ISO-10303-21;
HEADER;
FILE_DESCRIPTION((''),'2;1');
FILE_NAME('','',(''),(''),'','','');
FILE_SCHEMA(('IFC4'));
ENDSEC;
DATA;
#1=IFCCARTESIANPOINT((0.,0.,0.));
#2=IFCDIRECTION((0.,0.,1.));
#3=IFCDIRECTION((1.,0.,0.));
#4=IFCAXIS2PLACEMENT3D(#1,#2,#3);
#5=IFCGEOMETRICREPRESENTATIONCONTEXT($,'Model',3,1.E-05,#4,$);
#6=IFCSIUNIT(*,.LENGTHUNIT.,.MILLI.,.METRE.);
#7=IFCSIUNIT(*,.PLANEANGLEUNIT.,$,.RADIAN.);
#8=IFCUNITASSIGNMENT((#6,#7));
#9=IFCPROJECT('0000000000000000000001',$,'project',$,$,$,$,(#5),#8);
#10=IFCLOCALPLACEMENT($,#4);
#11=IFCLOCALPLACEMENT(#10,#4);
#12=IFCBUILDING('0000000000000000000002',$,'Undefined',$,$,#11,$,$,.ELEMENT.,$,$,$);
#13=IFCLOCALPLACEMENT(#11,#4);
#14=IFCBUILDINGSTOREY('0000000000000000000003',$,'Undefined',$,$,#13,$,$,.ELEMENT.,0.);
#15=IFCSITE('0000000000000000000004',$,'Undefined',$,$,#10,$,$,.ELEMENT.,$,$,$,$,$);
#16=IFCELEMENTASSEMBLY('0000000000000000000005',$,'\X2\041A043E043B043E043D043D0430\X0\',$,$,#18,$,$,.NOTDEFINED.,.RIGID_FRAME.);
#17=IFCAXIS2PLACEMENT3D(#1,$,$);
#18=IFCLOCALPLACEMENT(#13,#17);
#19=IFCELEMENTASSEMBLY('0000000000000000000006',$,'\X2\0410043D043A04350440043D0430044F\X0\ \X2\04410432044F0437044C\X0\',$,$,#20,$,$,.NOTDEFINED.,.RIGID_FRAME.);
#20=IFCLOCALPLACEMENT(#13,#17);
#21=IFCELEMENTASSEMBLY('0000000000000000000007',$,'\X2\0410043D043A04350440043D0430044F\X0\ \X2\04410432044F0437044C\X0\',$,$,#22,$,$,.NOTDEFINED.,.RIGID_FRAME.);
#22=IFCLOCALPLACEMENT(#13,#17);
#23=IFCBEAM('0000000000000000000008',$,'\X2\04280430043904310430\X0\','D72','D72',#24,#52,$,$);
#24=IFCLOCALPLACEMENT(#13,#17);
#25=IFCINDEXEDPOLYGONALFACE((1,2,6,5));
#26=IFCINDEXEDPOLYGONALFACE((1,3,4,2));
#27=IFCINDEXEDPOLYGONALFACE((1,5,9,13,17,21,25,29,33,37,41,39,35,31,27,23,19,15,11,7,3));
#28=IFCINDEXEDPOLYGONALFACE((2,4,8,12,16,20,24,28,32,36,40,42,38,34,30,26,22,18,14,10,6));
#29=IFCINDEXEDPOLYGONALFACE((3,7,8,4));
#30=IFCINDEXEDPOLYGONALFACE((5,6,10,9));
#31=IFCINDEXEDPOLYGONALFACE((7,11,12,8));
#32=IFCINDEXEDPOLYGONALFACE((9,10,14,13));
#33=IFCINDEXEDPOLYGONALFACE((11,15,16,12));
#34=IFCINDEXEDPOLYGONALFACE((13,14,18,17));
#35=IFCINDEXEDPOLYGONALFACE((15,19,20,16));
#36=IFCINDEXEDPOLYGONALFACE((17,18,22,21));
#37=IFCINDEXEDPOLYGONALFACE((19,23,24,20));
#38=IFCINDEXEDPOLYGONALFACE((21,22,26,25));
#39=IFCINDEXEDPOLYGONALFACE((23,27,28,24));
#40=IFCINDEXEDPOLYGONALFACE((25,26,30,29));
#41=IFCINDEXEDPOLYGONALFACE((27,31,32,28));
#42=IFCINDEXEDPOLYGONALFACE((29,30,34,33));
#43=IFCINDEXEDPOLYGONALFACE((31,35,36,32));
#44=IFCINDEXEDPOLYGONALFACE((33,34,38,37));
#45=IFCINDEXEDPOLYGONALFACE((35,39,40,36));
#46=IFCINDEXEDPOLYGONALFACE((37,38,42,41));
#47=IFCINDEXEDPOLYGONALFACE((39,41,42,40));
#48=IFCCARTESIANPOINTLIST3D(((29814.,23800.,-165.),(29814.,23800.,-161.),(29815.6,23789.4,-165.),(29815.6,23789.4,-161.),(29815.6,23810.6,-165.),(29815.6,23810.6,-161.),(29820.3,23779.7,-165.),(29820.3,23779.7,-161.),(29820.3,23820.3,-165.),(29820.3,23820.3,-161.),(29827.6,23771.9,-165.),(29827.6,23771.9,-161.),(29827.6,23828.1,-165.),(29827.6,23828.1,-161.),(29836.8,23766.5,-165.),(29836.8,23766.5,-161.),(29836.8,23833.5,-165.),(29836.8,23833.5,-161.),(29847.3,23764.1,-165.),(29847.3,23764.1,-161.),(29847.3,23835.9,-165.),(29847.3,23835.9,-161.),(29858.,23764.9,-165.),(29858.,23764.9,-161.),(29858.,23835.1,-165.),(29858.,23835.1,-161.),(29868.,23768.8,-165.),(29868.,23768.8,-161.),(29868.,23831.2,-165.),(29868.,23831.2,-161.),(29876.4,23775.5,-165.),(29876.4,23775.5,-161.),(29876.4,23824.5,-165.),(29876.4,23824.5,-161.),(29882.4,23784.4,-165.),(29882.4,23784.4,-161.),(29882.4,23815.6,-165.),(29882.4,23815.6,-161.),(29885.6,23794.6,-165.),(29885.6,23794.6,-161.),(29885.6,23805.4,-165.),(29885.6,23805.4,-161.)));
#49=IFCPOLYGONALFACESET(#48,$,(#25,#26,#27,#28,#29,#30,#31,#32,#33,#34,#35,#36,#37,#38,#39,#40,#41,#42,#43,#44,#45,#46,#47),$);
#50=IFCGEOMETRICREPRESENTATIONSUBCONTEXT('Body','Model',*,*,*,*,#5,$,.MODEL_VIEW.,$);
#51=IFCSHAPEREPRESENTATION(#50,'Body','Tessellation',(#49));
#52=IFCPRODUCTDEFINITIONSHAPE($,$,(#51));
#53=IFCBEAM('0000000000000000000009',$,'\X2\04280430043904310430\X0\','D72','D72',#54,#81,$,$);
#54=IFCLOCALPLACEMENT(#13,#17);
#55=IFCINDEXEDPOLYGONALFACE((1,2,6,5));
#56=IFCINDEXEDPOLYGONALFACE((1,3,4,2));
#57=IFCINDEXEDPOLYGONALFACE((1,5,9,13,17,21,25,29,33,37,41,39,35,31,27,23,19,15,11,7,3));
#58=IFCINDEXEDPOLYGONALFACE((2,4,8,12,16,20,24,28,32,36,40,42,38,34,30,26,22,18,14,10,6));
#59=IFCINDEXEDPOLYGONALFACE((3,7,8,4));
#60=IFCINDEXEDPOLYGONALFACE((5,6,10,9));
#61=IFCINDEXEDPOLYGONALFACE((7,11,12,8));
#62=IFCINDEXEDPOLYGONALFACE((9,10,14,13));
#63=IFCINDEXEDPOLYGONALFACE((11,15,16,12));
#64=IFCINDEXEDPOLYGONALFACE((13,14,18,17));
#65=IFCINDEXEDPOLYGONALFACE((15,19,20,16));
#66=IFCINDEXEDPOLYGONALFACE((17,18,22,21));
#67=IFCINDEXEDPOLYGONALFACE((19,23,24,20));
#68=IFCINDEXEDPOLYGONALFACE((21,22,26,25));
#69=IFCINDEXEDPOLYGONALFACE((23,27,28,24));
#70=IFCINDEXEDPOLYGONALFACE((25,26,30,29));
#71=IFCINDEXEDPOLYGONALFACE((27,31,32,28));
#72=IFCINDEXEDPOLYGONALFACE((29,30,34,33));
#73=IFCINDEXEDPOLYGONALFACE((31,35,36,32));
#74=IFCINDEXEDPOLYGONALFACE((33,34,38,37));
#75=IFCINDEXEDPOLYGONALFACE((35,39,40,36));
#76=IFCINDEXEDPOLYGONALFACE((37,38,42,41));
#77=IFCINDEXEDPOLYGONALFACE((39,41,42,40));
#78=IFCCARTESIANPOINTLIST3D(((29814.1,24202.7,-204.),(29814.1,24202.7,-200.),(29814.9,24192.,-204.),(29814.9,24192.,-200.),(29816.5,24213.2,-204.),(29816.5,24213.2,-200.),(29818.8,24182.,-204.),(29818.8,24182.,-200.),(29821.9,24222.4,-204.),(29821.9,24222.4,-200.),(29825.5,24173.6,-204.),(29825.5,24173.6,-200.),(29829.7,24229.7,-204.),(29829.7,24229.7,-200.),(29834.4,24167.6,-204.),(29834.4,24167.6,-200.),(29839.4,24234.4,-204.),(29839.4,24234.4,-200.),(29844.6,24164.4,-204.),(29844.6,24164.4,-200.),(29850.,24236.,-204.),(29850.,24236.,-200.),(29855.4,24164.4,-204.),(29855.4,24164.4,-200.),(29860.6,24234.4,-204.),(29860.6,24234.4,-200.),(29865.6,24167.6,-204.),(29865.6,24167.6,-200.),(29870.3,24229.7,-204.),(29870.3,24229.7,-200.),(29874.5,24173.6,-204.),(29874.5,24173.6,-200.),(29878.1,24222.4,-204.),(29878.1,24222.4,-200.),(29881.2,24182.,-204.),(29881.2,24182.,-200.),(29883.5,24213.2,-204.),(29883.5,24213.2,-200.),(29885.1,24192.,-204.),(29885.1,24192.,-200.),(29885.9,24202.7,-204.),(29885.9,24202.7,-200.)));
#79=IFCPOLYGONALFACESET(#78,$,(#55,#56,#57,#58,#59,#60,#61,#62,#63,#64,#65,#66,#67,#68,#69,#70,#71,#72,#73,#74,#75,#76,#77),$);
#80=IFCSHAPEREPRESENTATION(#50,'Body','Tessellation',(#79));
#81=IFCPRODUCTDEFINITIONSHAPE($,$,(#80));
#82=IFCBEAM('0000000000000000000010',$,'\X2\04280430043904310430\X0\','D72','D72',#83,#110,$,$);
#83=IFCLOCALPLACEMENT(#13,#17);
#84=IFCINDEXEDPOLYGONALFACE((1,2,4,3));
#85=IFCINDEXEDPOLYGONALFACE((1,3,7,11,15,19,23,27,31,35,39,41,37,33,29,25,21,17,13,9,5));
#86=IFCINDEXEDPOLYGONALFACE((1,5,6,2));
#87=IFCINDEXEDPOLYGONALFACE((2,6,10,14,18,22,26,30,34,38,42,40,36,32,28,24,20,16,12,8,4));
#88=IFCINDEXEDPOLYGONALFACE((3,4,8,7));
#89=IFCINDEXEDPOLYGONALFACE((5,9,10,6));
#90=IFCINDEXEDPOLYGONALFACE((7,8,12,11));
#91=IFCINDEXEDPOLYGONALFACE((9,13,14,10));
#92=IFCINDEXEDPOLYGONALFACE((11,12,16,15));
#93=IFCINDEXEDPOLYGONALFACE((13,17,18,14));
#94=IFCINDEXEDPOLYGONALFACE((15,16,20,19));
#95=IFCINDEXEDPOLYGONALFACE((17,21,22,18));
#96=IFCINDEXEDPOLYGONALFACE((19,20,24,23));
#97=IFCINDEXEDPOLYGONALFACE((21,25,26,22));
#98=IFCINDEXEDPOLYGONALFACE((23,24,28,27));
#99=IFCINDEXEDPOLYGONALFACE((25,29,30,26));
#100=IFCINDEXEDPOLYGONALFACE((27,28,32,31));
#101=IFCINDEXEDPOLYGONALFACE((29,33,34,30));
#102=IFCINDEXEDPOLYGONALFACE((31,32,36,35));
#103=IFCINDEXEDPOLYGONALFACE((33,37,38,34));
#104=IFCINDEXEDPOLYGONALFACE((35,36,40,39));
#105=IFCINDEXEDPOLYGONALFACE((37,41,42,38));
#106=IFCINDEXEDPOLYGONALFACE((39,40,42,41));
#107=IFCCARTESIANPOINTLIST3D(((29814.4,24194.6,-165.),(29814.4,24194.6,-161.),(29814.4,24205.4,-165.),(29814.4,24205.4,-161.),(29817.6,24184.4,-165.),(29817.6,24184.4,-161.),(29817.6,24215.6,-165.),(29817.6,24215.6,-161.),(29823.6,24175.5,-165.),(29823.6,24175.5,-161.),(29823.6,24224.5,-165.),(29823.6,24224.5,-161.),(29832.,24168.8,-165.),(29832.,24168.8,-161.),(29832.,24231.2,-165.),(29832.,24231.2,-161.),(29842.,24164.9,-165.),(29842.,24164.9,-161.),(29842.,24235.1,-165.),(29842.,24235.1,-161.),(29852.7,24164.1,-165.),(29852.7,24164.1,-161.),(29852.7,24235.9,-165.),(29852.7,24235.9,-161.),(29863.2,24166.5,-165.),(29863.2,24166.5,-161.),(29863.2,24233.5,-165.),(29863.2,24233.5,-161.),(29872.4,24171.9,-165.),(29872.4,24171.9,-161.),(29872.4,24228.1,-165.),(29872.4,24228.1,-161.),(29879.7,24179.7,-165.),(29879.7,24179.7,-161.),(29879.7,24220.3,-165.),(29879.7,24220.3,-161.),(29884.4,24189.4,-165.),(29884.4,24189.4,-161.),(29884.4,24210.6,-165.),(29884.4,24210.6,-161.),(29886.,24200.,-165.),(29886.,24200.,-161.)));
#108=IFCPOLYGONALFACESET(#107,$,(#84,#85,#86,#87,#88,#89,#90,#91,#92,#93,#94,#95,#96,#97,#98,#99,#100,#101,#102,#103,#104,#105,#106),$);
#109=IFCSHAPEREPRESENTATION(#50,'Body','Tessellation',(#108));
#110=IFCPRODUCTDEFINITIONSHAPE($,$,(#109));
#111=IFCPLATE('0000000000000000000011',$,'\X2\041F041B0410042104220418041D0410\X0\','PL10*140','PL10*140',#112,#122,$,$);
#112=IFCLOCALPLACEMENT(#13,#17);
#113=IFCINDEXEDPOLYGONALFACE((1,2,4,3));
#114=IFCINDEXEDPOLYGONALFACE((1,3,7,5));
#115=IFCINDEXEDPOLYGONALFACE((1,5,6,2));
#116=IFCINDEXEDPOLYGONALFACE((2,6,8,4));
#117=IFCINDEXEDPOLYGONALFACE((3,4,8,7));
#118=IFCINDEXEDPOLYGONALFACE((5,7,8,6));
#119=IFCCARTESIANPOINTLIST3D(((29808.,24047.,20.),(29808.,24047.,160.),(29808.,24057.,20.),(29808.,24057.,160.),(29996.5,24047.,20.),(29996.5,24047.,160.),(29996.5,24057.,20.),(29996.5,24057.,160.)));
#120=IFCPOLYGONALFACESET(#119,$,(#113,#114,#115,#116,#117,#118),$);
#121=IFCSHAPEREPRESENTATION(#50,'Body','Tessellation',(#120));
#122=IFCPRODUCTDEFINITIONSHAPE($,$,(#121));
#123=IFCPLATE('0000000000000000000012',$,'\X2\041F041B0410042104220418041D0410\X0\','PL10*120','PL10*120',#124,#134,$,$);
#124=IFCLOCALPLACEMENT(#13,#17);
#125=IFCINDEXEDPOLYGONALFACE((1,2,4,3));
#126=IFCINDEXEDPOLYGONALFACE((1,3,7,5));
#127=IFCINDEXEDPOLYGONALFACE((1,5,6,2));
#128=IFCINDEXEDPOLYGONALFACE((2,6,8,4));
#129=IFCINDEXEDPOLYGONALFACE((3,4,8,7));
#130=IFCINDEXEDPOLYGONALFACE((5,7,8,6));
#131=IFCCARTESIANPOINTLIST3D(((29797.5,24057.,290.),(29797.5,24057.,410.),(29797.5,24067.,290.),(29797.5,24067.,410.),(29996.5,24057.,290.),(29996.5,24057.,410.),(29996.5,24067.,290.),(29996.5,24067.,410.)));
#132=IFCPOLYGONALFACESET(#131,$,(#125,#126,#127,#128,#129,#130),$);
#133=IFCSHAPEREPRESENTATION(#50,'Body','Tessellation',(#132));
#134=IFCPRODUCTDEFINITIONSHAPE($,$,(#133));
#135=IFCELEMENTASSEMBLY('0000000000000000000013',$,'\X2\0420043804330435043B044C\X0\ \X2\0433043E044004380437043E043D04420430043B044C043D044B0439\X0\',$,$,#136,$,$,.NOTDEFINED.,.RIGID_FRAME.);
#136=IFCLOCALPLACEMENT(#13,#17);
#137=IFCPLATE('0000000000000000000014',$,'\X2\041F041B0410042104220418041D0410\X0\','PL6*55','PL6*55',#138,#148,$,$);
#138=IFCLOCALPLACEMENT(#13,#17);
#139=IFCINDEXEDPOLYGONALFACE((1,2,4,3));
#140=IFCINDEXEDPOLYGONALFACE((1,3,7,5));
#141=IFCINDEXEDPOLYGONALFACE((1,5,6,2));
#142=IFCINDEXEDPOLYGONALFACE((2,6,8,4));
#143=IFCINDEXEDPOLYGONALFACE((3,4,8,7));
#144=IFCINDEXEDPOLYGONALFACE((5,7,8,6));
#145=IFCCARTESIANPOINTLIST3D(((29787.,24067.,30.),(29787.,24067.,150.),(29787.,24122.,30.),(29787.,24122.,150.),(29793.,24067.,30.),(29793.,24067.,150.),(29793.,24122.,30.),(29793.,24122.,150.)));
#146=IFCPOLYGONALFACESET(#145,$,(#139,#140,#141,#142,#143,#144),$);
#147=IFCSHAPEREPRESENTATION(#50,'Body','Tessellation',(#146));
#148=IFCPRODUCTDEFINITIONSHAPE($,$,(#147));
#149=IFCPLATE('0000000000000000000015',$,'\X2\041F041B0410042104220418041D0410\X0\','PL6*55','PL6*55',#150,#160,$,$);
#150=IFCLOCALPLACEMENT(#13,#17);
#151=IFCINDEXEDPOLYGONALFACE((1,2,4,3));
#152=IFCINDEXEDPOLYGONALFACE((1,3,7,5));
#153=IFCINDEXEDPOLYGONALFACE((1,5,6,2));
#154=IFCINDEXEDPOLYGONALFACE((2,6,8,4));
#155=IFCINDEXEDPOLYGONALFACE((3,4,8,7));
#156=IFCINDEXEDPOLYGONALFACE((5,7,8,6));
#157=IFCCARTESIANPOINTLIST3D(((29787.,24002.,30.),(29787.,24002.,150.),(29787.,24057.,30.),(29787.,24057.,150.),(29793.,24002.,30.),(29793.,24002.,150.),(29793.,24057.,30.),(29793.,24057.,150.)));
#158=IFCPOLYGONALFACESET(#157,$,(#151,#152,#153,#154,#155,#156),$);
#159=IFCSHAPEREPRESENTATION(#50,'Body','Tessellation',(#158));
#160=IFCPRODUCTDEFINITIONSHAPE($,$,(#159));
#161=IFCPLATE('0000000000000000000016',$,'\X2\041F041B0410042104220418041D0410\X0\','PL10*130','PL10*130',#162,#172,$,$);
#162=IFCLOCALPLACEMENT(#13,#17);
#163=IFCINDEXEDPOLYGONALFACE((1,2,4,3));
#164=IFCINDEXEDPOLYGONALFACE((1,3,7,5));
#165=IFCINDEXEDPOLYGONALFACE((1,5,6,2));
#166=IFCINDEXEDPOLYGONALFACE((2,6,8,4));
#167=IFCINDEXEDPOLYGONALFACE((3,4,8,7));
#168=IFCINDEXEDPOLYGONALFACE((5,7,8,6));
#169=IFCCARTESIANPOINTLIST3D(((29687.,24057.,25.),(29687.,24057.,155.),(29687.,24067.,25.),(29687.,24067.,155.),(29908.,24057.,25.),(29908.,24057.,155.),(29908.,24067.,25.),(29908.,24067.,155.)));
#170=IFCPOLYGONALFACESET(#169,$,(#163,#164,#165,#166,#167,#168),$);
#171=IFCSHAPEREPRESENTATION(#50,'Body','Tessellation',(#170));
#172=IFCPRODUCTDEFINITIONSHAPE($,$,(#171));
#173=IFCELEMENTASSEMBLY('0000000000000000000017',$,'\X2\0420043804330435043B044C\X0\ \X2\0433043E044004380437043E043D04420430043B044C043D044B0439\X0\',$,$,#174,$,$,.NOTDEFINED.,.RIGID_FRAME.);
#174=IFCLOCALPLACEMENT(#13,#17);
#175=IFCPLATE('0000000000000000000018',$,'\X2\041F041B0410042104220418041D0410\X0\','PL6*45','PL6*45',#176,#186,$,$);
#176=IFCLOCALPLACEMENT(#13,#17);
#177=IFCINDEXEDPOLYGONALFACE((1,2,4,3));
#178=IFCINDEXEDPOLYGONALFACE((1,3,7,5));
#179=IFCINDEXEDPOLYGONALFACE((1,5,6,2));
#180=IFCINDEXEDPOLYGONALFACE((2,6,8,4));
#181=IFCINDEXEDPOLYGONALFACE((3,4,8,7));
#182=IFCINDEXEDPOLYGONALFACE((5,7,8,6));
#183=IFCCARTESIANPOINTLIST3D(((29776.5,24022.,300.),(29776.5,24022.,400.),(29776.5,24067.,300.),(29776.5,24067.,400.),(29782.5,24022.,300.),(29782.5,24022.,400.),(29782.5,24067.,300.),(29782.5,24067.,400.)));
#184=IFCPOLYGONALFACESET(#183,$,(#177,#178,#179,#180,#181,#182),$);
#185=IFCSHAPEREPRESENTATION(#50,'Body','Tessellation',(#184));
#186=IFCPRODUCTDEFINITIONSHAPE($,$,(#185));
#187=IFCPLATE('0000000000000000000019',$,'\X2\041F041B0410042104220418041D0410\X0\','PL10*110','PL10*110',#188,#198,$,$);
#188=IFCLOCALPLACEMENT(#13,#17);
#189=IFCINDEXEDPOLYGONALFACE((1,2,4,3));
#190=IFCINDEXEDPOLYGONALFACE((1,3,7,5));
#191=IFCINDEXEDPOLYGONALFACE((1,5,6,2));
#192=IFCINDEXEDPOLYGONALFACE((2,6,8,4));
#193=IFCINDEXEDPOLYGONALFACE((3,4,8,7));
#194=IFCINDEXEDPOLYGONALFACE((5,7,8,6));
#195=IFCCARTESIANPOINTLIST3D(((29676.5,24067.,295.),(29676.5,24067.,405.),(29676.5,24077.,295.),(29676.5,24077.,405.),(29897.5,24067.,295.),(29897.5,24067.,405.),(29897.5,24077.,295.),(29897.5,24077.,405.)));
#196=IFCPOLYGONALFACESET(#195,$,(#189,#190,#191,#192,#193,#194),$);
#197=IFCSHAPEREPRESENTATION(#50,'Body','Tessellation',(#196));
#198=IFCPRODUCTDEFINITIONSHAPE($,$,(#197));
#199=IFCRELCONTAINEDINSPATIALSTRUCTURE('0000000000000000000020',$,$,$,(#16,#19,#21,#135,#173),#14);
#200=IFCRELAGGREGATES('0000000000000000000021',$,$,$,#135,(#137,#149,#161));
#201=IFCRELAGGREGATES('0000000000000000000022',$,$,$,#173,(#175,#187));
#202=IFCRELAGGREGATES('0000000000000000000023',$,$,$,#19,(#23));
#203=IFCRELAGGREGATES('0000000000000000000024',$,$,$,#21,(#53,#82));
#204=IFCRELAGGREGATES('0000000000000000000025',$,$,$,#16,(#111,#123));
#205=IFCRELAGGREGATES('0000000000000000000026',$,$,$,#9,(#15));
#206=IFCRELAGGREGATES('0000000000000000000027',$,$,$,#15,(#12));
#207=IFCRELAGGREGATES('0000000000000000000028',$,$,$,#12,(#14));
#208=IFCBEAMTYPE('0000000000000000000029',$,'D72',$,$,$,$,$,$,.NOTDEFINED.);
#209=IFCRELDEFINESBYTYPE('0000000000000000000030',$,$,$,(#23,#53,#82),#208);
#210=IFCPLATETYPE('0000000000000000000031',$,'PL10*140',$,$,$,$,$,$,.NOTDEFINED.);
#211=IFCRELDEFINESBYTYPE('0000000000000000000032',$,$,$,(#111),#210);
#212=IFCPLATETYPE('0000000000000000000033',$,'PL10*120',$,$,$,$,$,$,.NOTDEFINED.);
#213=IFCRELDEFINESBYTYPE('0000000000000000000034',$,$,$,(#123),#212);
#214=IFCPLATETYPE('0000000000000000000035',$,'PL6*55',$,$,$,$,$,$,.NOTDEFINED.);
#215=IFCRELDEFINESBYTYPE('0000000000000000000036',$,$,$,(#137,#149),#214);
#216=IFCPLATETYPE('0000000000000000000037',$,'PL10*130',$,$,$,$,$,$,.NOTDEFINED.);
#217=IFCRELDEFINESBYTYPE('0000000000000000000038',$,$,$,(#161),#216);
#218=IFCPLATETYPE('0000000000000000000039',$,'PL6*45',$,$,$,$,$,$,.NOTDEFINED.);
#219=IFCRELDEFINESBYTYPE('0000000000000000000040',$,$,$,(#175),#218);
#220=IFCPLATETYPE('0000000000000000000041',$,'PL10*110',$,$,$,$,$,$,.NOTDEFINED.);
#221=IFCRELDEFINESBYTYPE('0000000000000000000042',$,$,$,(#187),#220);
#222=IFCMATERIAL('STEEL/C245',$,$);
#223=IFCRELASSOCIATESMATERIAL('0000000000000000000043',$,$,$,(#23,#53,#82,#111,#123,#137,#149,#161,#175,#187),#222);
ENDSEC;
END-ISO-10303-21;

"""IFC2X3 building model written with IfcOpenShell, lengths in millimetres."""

from ifc_helpers import new_model, si_unit, frame, origin_with_axes, origin_2d_with_axis, place, context, subcontext, project, spatial, polyline, circle, outline, extrude, material, type_object, element, aggregate, save


model = new_model("IFC2X3")

# Units and contexts
model_context = context("Model", 3, precision=1e-05, world=origin_with_axes())
body_context = subcontext(model_context, "Body", "Model", "MODEL_VIEW")
ifc_project = project(units=[si_unit("LENGTHUNIT", "METRE", prefix="MILLI"), si_unit("PLANEANGLEUNIT", "RADIAN")], contexts=[model_context])

# Site, building, storey
site_placement = place(None, origin_with_axes())
site = spatial("IfcSite", under=ifc_project, at=site_placement, Name="Undefined", CompositionType="ELEMENT")
building_placement = place(site_placement, origin_with_axes())
building = spatial("IfcBuilding", under=site, at=building_placement, Name="Undefined", CompositionType="ELEMENT")
storey_placement = place(building_placement, origin_with_axes())
storey = spatial("IfcBuildingStorey", under=building, at=storey_placement, Name="Undefined", CompositionType="ELEMENT", Elevation=0.0)

# Element assembly
ifc_material_1 = material(Name="STEEL/C245")
assembly_1_placement = place(storey_placement, origin_with_axes())
assembly_1 = element("IfcElementAssembly", 1, at=assembly_1_placement, inside=storey, Name="Колонна", AssemblyPlace="NOTDEFINED", PredefinedType="RIGID_FRAME")

# Element assemblies
assembly_2_placement = place(storey_placement, origin_with_axes())
assembly_2 = element("IfcElementAssembly", 2, at=assembly_2_placement, inside=storey, Name="Анкерная связь", AssemblyPlace="NOTDEFINED", PredefinedType="RIGID_FRAME")
assembly_3_placement = place(storey_placement, origin_with_axes())
assembly_3 = element("IfcElementAssembly", 3, at=assembly_3_placement, inside=storey, Name="Анкерная связь", AssemblyPlace="NOTDEFINED", PredefinedType="RIGID_FRAME")

# Beams
beam_type_1 = type_object("IfcBeamType", Name="D72", PredefinedType="NOTDEFINED")
beam_1_placement = place(assembly_2_placement, frame((29850.0, 23800.0, -161.0), z_axis=(0.0, -1.0, 0.0), x_axis=(0.0, 0.0, -1.0)))
beam_1 = element("IfcBeam", 4, at=beam_1_placement, type_object=beam_type_1, material=ifc_material_1, Name="Шайба", Description="D72", ObjectType="D72", context=body_context, shape_type="SweptSolid", body=[
    extrude(circle(Radius=36.0, at=origin_2d_with_axis()), frame((4.0, 0.0, 0.0), z_axis=(-1.0, 0.0, 0.0), x_axis=(0.0, -1.0, 0.0)), (0.0, 0.0, 1.0), 4.0),
])
beam_2_placement = place(assembly_3_placement, frame((29850.0, 24200.0, -200.0), z_axis=(-1.0, 0.0, 0.0), x_axis=(0.0, 0.0, -1.0)))
beam_2 = element("IfcBeam", 5, at=beam_2_placement, type_object=beam_type_1, material=ifc_material_1, Name="Шайба", Description="D72", ObjectType="D72", context=body_context, shape_type="SweptSolid", body=[
    extrude(circle(Radius=36.0, at=origin_2d_with_axis()), frame((4.0, 0.0, 0.0), z_axis=(-1.0, 0.0, 0.0), x_axis=(0.0, -1.0, 0.0)), (0.0, 0.0, 1.0), 4.0),
])
beam_3_placement = place(assembly_3_placement, frame((29850.0, 24200.0, -161.0), z_axis=(0.0, 1.0, 0.0), x_axis=(0.0, 0.0, -1.0)))
beam_3 = element("IfcBeam", 6, at=beam_3_placement, type_object=beam_type_1, material=ifc_material_1, Name="Шайба", Description="D72", ObjectType="D72", context=body_context, shape_type="SweptSolid", body=[
    extrude(circle(Radius=36.0, at=origin_2d_with_axis()), frame((4.0, 0.0, 0.0), z_axis=(-1.0, 0.0, 0.0), x_axis=(0.0, -1.0, 0.0)), (0.0, 0.0, 1.0), 4.0),
])

# Plates
plate_type_1 = type_object("IfcPlateType", Name="PL10*140", PredefinedType="NOTDEFINED")
plate_1_placement = place(assembly_1_placement, frame((29996.5, 24052.0, 20.0), z_axis=(0.0, 1.0, 0.0), x_axis=(-1.0, 0.0, 0.0)))
plate_1 = element("IfcPlate", 7, at=plate_1_placement, type_object=plate_type_1, material=ifc_material_1, Name="ПЛАСТИНА", Description="PL10*140", ObjectType="PL10*140", context=body_context, shape_type="SweptSolid", body=[
    extrude(outline(polyline([(0.0, 0.0), (188.5, 0.0), (188.5, 140.0), (0.0, 140.0), (0.0, 0.0)])), frame((0.0, 0.0, -5.0), z_axis=(0.0, 0.0, 1.0), x_axis=(1.0, 0.0, 0.0)), (0.0, 0.0, 1.0), 10.0),
])
plate_type_2 = type_object("IfcPlateType", Name="PL10*120", PredefinedType="NOTDEFINED")
plate_2_placement = place(assembly_1_placement, frame((29996.5, 24062.0, 290.0), z_axis=(0.0, 1.0, 0.0), x_axis=(-1.0, 0.0, 0.0)))
plate_2 = element("IfcPlate", 8, at=plate_2_placement, type_object=plate_type_2, material=ifc_material_1, Name="ПЛАСТИНА", Description="PL10*120", ObjectType="PL10*120", context=body_context, shape_type="SweptSolid", body=[
    extrude(outline(polyline([(0.0, 0.0), (199.0, 0.0), (199.0, 120.0), (0.0, 120.0), (0.0, 0.0)])), frame((0.0, 0.0, -5.0), z_axis=(0.0, 0.0, 1.0), x_axis=(1.0, 0.0, 0.0)), (0.0, 0.0, 1.0), 10.0),
])

# Element assemblies, plates
assembly_4_placement = place(storey_placement, origin_with_axes())
assembly_4 = element("IfcElementAssembly", 9, at=assembly_4_placement, inside=storey, Name="Ригель горизонтальный", AssemblyPlace="NOTDEFINED", PredefinedType="RIGID_FRAME")
plate_type_3 = type_object("IfcPlateType", Name="PL6*55", PredefinedType="NOTDEFINED")
plate_3_placement = place(assembly_4_placement, frame((29790.0, 24094.5, 150.0), z_axis=(-1.0, 0.0, 0.0), x_axis=(0.0, 0.0, -1.0)))
plate_3 = element("IfcPlate", 10, at=plate_3_placement, type_object=plate_type_3, material=ifc_material_1, Name="ПЛАСТИНА", Description="PL6*55", ObjectType="PL6*55", context=body_context, shape_type="SweptSolid", body=[
    extrude(outline(polyline([(120.0, 27.5), (120.0, -27.5), (0.0, -27.5), (0.0, 27.5), (120.0, 27.5)])), frame((0.0, 0.0, -3.0), z_axis=(0.0, 0.0, 1.0), x_axis=(1.0, 0.0, 0.0)), (0.0, 0.0, 1.0), 6.0),
])
plate_4_placement = place(assembly_4_placement, frame((29790.0, 24029.5, 150.0), z_axis=(1.0, 0.0, 0.0), x_axis=(0.0, 0.0, -1.0)))
plate_4 = element("IfcPlate", 11, at=plate_4_placement, type_object=plate_type_3, material=ifc_material_1, Name="ПЛАСТИНА", Description="PL6*55", ObjectType="PL6*55", context=body_context, shape_type="SweptSolid", body=[
    extrude(outline(polyline([(120.0, -27.5), (0.0, -27.5), (0.0, 27.5), (120.0, 27.5), (120.0, -27.5)])), frame((0.0, 0.0, -3.0), z_axis=(0.0, 0.0, 1.0), x_axis=(1.0, 0.0, 0.0)), (0.0, 0.0, 1.0), 6.0),
])
plate_type_4 = type_object("IfcPlateType", Name="PL10*130", PredefinedType="NOTDEFINED")
plate_5_placement = place(assembly_4_placement, frame((29908.0, 24062.0, 90.0), z_axis=(0.0, 1.0, 0.0), x_axis=(-1.0, 0.0, 0.0)))
plate_5 = element("IfcPlate", 12, at=plate_5_placement, type_object=plate_type_4, material=ifc_material_1, Name="ПЛАСТИНА", Description="PL10*130", ObjectType="PL10*130", context=body_context, shape_type="SweptSolid", body=[
    extrude(outline(polyline([(221.0, -65.0), (0.0, -65.0), (0.0, 65.0), (221.0, 65.0), (221.0, -65.0)])), frame((0.0, 0.0, -5.0), z_axis=(0.0, 0.0, 1.0), x_axis=(1.0, 0.0, 0.0)), (0.0, 0.0, 1.0), 10.0),
])
assembly_5_placement = place(storey_placement, origin_with_axes())
assembly_5 = element("IfcElementAssembly", 13, at=assembly_5_placement, inside=storey, Name="Ригель горизонтальный", AssemblyPlace="NOTDEFINED", PredefinedType="RIGID_FRAME")
plate_type_5 = type_object("IfcPlateType", Name="PL6*45", PredefinedType="NOTDEFINED")
plate_6_placement = place(assembly_5_placement, frame((29779.5, 24044.5, 400.0), z_axis=(1.0, 0.0, 0.0), x_axis=(0.0, 0.0, -1.0)))
plate_6 = element("IfcPlate", 14, at=plate_6_placement, type_object=plate_type_5, material=ifc_material_1, Name="ПЛАСТИНА", Description="PL6*45", ObjectType="PL6*45", context=body_context, shape_type="SweptSolid", body=[
    extrude(outline(polyline([(100.0, -22.5), (0.0, -22.5), (0.0, 22.5), (100.0, 22.5), (100.0, -22.5)])), frame((0.0, 0.0, -3.0), z_axis=(0.0, 0.0, 1.0), x_axis=(1.0, 0.0, 0.0)), (0.0, 0.0, 1.0), 6.0),
])
plate_type_6 = type_object("IfcPlateType", Name="PL10*110", PredefinedType="NOTDEFINED")
plate_7_placement = place(assembly_5_placement, frame((29897.5, 24072.0, 350.0), z_axis=(0.0, 1.0, 0.0), x_axis=(-1.0, 0.0, 0.0)))
plate_7 = element("IfcPlate", 15, at=plate_7_placement, type_object=plate_type_6, material=ifc_material_1, Name="ПЛАСТИНА", Description="PL10*110", ObjectType="PL10*110", context=body_context, shape_type="SweptSolid", body=[
    extrude(outline(polyline([(221.0, -55.0), (0.0, -55.0), (0.0, 55.0), (221.0, 55.0), (221.0, -55.0)])), frame((0.0, 0.0, -5.0), z_axis=(0.0, 0.0, 1.0), x_axis=(1.0, 0.0, 0.0)), (0.0, 0.0, 1.0), 10.0),
])

aggregate(assembly_4, [plate_3, plate_4, plate_5])
aggregate(assembly_5, [plate_6, plate_7])
aggregate(assembly_2, [beam_1])
aggregate(assembly_3, [beam_2, beam_3])
aggregate(assembly_1, [plate_1, plate_2])

save(model, "model.ifc")
